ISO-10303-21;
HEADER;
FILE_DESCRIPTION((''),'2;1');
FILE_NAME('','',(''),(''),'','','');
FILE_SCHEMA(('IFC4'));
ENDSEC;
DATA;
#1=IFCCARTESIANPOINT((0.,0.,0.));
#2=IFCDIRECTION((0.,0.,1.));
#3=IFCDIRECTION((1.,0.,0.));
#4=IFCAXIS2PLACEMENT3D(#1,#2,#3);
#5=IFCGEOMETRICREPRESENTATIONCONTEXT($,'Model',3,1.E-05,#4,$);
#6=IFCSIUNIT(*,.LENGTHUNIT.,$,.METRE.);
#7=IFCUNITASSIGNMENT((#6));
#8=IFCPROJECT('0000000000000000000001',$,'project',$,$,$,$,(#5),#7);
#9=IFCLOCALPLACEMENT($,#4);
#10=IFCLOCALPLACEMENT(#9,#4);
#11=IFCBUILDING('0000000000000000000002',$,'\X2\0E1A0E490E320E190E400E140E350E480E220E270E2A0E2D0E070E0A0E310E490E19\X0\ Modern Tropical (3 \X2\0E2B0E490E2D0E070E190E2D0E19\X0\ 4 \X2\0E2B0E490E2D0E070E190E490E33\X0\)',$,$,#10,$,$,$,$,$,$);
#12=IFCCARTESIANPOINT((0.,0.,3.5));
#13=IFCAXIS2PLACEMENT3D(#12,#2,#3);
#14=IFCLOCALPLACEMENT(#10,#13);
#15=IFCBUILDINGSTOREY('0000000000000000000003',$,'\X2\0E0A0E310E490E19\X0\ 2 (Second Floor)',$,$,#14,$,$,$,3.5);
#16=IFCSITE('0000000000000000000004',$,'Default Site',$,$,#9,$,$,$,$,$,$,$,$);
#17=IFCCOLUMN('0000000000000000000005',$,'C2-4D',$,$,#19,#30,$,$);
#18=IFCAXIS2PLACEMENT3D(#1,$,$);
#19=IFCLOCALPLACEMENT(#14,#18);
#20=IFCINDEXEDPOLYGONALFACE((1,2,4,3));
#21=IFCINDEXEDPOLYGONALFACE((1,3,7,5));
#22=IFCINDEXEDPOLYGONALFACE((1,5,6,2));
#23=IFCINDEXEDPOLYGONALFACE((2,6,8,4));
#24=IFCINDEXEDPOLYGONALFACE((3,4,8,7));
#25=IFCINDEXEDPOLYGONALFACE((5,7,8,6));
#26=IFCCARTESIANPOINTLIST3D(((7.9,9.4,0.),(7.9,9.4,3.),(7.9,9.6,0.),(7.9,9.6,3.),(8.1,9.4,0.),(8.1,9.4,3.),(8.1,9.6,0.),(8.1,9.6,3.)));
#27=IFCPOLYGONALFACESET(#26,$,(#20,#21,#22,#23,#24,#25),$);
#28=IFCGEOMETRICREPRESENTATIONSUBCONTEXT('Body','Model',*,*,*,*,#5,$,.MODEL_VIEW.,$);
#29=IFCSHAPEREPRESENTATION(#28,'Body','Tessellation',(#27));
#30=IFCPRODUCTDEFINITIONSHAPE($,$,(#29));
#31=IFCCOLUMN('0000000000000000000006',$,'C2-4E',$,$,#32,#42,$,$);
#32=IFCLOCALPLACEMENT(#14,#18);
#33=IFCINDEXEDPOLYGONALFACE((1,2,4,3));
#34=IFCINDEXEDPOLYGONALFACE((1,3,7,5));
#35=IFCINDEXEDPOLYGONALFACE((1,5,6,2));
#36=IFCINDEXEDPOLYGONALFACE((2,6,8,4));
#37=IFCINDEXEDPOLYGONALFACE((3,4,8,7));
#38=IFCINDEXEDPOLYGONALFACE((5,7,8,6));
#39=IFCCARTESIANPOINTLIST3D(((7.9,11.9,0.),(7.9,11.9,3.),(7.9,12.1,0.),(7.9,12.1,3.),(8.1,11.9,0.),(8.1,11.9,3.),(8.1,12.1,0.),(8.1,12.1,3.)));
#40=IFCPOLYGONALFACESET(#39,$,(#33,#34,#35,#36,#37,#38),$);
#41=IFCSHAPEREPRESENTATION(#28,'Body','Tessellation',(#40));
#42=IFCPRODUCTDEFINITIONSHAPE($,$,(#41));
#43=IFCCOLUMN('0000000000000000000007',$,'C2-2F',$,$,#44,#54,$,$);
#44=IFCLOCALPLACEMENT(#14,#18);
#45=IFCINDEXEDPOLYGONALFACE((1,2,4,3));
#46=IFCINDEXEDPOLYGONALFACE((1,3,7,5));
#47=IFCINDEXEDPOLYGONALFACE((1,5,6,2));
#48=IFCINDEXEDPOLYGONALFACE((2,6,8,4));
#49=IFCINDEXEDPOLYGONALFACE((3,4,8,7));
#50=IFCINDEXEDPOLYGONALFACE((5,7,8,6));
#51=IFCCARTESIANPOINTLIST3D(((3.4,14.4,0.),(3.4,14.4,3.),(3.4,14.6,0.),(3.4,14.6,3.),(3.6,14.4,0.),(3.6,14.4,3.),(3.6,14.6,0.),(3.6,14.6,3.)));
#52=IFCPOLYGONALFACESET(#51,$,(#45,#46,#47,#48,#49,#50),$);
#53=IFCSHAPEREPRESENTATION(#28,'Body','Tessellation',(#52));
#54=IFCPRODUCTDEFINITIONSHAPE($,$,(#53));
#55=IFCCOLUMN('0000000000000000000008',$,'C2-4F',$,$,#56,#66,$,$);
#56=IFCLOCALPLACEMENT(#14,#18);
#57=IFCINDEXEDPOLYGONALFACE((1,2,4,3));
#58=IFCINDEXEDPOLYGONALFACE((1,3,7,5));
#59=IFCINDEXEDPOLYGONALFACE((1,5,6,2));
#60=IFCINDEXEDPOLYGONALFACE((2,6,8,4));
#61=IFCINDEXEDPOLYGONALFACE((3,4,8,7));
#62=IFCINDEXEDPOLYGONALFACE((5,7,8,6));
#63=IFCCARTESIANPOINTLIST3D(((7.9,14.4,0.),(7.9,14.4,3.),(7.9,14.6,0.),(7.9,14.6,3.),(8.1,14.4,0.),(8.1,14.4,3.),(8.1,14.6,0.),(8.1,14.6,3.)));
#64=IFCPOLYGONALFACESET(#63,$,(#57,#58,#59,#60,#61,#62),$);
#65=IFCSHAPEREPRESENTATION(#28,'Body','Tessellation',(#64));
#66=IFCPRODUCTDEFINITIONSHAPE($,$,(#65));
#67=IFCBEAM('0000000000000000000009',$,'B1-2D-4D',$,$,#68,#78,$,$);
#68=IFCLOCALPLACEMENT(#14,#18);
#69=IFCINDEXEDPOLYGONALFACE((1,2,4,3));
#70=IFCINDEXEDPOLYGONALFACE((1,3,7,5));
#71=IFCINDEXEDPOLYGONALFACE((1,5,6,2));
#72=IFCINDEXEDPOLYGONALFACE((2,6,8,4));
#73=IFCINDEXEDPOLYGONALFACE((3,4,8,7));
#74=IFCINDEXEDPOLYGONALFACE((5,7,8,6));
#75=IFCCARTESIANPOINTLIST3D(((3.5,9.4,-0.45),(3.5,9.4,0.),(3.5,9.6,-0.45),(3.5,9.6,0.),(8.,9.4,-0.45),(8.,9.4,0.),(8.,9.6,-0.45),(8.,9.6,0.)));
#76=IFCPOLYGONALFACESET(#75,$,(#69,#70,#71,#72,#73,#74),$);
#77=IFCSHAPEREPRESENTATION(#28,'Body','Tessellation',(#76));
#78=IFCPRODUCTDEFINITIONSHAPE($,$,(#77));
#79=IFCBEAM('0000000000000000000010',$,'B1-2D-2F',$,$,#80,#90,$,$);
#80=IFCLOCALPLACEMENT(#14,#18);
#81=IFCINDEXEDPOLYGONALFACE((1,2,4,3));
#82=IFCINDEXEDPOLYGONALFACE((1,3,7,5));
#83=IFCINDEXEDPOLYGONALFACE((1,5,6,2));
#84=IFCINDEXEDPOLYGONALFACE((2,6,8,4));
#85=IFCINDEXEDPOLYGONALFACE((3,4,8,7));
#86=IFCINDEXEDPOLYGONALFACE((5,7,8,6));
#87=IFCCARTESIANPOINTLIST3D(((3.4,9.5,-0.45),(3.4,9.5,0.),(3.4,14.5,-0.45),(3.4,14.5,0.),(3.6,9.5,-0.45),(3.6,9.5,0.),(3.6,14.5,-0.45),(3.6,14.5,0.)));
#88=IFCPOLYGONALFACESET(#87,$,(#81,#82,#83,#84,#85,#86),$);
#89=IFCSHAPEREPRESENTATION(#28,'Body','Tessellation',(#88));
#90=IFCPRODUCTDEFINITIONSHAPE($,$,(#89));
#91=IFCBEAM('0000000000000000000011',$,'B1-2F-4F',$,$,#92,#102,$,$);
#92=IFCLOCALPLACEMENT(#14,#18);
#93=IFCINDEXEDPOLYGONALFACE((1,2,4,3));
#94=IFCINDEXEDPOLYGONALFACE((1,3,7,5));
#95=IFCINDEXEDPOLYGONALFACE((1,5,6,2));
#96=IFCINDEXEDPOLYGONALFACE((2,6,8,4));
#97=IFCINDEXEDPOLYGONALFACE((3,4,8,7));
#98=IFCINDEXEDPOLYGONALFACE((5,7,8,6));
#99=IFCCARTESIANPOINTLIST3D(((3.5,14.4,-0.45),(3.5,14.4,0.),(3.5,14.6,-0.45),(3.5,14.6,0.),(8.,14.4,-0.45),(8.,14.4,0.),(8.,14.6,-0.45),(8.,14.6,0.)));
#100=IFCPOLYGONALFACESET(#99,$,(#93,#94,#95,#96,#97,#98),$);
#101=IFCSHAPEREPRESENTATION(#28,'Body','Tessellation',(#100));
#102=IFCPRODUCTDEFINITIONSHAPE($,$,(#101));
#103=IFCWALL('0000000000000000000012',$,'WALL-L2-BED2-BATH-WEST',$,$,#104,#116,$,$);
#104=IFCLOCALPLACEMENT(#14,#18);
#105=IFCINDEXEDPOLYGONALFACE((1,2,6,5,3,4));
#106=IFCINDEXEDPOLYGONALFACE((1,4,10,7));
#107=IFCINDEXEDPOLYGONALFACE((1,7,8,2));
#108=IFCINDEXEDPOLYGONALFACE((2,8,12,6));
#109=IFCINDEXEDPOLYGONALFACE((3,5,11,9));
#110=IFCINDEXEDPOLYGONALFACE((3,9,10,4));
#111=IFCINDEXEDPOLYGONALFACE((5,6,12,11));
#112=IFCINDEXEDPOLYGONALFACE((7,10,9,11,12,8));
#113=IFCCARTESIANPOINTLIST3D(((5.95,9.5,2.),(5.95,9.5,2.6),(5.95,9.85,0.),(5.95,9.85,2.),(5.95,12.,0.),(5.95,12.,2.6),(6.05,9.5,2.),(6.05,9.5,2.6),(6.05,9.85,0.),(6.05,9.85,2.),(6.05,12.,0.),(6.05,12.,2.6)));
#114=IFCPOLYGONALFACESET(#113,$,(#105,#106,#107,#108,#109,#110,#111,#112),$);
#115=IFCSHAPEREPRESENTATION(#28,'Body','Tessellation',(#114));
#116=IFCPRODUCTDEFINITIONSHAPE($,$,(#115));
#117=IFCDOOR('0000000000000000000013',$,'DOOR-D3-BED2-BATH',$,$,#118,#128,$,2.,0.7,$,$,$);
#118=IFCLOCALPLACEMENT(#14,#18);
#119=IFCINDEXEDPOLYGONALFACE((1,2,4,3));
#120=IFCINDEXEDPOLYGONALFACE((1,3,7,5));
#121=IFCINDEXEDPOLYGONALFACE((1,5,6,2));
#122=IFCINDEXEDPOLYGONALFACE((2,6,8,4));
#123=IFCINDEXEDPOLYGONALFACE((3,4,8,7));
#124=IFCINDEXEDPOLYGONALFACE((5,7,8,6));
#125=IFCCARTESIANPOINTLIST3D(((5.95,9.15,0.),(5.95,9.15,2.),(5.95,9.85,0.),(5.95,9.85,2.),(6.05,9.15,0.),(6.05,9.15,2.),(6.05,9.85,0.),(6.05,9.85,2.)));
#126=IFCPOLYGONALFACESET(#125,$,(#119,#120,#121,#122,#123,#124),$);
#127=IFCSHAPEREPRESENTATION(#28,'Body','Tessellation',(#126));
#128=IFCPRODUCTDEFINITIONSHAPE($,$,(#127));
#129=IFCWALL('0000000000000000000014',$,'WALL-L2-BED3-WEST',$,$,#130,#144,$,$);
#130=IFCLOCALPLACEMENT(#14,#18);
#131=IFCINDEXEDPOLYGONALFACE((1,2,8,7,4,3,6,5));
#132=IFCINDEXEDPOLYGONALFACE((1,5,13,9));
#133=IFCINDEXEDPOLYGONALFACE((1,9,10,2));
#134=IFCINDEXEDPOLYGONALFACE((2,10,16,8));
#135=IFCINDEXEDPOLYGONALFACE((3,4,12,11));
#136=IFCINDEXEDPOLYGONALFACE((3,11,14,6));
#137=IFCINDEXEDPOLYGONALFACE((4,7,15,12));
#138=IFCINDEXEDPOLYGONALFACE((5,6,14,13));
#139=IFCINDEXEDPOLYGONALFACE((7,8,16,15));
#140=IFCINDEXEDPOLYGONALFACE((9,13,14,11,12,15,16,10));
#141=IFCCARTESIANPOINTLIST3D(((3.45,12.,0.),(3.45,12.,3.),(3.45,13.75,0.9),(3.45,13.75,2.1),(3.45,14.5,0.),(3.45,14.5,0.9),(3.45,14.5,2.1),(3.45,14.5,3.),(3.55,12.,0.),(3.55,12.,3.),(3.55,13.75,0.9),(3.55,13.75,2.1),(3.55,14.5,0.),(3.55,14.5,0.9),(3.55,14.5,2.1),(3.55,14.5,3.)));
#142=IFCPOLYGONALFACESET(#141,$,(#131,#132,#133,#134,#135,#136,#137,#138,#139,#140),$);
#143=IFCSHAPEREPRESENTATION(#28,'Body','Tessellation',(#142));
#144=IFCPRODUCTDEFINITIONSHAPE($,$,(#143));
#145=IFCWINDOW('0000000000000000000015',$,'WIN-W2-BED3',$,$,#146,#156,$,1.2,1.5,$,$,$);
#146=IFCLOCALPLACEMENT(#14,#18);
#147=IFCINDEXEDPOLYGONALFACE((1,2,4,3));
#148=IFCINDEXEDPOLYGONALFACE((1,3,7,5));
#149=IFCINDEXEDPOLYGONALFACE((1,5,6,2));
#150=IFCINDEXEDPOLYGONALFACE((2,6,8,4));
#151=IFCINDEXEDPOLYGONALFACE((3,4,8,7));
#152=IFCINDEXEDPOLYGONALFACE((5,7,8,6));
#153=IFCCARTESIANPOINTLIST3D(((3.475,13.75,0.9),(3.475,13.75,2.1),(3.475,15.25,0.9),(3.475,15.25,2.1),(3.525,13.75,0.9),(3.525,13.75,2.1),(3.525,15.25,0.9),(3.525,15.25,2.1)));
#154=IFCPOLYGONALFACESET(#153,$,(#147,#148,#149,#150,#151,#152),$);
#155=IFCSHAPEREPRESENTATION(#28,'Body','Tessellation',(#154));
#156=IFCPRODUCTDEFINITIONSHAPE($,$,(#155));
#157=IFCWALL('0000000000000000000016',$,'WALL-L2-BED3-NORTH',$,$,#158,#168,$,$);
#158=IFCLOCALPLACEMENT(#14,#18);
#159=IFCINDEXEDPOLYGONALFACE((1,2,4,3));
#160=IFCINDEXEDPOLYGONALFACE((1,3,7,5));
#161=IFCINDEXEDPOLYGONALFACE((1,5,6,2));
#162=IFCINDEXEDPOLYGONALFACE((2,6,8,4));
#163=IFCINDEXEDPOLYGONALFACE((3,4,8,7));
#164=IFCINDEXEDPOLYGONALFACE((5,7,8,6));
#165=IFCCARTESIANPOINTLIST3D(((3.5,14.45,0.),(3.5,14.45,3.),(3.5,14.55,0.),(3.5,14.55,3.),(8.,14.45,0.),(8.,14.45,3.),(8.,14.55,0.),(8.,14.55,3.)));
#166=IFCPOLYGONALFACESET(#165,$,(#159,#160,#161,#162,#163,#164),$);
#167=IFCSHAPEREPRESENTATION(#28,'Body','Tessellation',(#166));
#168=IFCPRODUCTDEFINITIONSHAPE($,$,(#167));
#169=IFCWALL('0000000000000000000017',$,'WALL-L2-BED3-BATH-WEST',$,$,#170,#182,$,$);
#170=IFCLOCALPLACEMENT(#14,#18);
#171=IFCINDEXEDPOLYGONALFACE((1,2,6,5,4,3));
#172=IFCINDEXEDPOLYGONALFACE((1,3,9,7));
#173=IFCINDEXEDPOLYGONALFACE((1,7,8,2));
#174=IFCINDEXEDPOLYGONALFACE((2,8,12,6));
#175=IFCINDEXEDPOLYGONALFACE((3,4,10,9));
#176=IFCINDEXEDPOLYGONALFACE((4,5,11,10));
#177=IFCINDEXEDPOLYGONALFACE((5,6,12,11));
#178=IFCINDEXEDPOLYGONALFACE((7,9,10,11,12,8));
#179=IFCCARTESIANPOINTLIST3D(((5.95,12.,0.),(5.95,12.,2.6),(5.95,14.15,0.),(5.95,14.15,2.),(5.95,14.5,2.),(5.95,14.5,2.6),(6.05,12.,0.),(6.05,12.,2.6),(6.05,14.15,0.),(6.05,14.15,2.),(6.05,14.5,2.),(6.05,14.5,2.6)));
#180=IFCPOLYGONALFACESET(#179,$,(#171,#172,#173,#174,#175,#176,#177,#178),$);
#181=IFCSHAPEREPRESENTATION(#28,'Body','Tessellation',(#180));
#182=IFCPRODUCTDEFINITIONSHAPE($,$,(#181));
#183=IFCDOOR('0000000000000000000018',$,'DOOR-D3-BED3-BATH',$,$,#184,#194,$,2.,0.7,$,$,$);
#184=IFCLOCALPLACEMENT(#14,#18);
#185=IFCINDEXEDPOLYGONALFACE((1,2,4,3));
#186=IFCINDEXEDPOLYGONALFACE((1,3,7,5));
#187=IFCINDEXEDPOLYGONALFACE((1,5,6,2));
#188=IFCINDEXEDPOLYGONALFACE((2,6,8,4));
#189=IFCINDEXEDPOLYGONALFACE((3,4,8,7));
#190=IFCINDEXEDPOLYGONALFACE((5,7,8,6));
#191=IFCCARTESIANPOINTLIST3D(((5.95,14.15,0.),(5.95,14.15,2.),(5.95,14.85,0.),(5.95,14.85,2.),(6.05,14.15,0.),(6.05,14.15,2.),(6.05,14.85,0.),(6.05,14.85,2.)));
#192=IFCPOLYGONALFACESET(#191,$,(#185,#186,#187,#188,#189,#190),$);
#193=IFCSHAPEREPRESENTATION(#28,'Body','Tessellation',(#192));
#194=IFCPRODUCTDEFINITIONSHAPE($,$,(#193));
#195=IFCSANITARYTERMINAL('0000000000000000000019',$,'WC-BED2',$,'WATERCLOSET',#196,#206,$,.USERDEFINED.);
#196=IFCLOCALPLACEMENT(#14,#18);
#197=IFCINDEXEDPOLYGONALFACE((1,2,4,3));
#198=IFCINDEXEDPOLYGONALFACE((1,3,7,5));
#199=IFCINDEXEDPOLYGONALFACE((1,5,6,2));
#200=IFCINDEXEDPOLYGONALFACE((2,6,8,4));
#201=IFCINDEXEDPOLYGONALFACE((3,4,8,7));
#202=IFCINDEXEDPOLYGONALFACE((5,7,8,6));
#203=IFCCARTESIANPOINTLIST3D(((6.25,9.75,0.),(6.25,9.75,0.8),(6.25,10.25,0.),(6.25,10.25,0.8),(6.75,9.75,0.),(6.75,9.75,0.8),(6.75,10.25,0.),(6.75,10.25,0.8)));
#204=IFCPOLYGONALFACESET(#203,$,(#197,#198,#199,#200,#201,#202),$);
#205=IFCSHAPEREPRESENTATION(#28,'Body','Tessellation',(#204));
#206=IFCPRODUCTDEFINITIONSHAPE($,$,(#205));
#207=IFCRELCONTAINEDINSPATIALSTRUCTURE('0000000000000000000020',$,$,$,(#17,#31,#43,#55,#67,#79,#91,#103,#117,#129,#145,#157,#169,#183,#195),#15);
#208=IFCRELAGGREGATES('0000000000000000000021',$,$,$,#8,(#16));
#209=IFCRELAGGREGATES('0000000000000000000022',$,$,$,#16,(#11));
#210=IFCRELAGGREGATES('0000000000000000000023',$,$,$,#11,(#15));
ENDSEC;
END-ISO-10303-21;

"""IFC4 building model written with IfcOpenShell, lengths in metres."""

from ifc_helpers import new_model, si_unit, frame, origin_with_axes, origin_2d, place, context, subcontext, project, spatial, rectangle, extrude, element, fill, save


model = new_model("IFC4")

# Units and contexts
model_context = context("Model", 3, precision=1e-05, world=origin_with_axes())
body_context = subcontext(model_context, "Body", "Model", "MODEL_VIEW")
ifc_project = project(units=[si_unit("LENGTHUNIT", "METRE")], contexts=[model_context])

# Site, building, storey
site_placement = place(None, origin_with_axes())
site = spatial("IfcSite", under=ifc_project, at=site_placement, Name="Default Site")
building_placement = place(site_placement, origin_with_axes())
building = spatial("IfcBuilding", under=site, at=building_placement, Name="บ้านเดี่ยวสองชั้น Modern Tropical (3 ห้องนอน 4 ห้องน้ำ)")
storey_placement = place(building_placement, frame((0.0, 0.0, 3.5), z_axis=(0.0, 0.0, 1.0), x_axis=(1.0, 0.0, 0.0)))
storey = spatial("IfcBuildingStorey", under=building, at=storey_placement, Name="ชั้น 2 (Second Floor)", Elevation=3.5)

# Columns
for number, where, z_axis, x_axis, name in (
    (1, (8.0, 9.5, 0.0), (0.0, 0.0, 1.0), (1.0, 0.0, 0.0), "C2-4D"),
    (2, (8.0, 12.0, 0.0), (0.0, 0.0, 1.0), (1.0, 0.0, 0.0), "C2-4E"),
    (3, (3.5, 14.5, 0.0), (0.0, 0.0, 1.0), (1.0, 0.0, 0.0), "C2-2F"),
    (4, (8.0, 14.5, 0.0), (0.0, 0.0, 1.0), (1.0, 0.0, 0.0), "C2-4F"),
):
    element("IfcColumn", number, at=place(storey_placement, frame(where, z_axis=z_axis, x_axis=x_axis)), inside=storey, Name=name, context=body_context, shape_type="SweptSolid", body=[
        extrude(rectangle(XDim=0.2, YDim=0.2, at=origin_2d()), origin_with_axes(), (0.0, 0.0, 1.0), 3.0),
    ])

# Beams
beam_1_placement = place(storey_placement, frame((3.5, 9.5, -0.225), z_axis=(1.0, 0.0, 0.0), x_axis=(0.0, 1.0, 0.0)))
element("IfcBeam", 5, at=beam_1_placement, inside=storey, Name="B1-2D-4D", context=body_context, shape_type="SweptSolid", body=[
    extrude(rectangle(XDim=0.2, YDim=0.45, at=origin_2d()), origin_with_axes(), (0.0, 0.0, 1.0), 4.5),
])
beam_2_placement = place(storey_placement, frame((3.5, 9.5, -0.225), z_axis=(0.0, 1.0, 0.0), x_axis=(-1.0, 0.0, 0.0)))
element("IfcBeam", 6, at=beam_2_placement, inside=storey, Name="B1-2D-2F", context=body_context, shape_type="SweptSolid", body=[
    extrude(rectangle(XDim=0.2, YDim=0.45, at=origin_2d()), origin_with_axes(), (0.0, 0.0, 1.0), 5.0),
])
beam_3_placement = place(storey_placement, frame((3.5, 14.5, -0.225), z_axis=(1.0, 0.0, 0.0), x_axis=(0.0, 1.0, 0.0)))
element("IfcBeam", 7, at=beam_3_placement, inside=storey, Name="B1-2F-4F", context=body_context, shape_type="SweptSolid", body=[
    extrude(rectangle(XDim=0.2, YDim=0.45, at=origin_2d()), origin_with_axes(), (0.0, 0.0, 1.0), 4.5),
])

# Wall, opening, door
wall_1_placement = place(storey_placement, frame((6.0, 10.75, 0.0), z_axis=(0.0, 0.0, 1.0), x_axis=(0.0, 1.0, 0.0)))
wall_1 = element("IfcWall", 8, at=wall_1_placement, inside=storey, Name="WALL-L2-BED2-BATH-WEST", context=body_context, shape_type="SweptSolid", body=[
    extrude(rectangle(XDim=2.5, YDim=0.1, at=origin_2d()), origin_with_axes(), (0.0, 0.0, 1.0), 2.6),
])
opening_1_placement = place(wall_1_placement, frame((-1.25, 0.0, 0.0), z_axis=(0.0, 0.0, 1.0), x_axis=(1.0, 0.0, 0.0)))
opening_1 = element("IfcOpeningElement", 9, at=opening_1_placement, cuts=wall_1, context=body_context, shape_type="SweptSolid", body=[
    extrude(rectangle(XDim=0.7, YDim=0.12, at=origin_2d()), origin_with_axes(), (0.0, 0.0, 1.0), 2.0),
])
door_1_placement = place(opening_1_placement, origin_with_axes())
door_1 = element("IfcDoor", 10, at=door_1_placement, inside=storey, Name="DOOR-D3-BED2-BATH", OverallHeight=2.0, OverallWidth=0.7, context=body_context, shape_type="SweptSolid", body=[
    extrude(rectangle(XDim=0.7, YDim=0.1, at=origin_2d()), origin_with_axes(), (0.0, 0.0, 1.0), 2.0),
])
fill(opening_1, door_1)

# Wall, opening, window
wall_2_placement = place(storey_placement, frame((3.5, 13.25, 0.0), z_axis=(0.0, 0.0, 1.0), x_axis=(0.0, 1.0, 0.0)))
wall_2 = element("IfcWall", 11, at=wall_2_placement, inside=storey, Name="WALL-L2-BED3-WEST", context=body_context, shape_type="SweptSolid", body=[
    extrude(rectangle(XDim=2.5, YDim=0.1, at=origin_2d()), origin_with_axes(), (0.0, 0.0, 1.0), 3.0),
])
opening_2_placement = place(wall_2_placement, frame((1.25, 0.0, 0.9), z_axis=(0.0, 0.0, 1.0), x_axis=(1.0, 0.0, 0.0)))
opening_2 = element("IfcOpeningElement", 12, at=opening_2_placement, cuts=wall_2, context=body_context, shape_type="SweptSolid", body=[
    extrude(rectangle(XDim=1.5, YDim=0.12, at=origin_2d()), origin_with_axes(), (0.0, 0.0, 1.0), 1.2),
])
window_placement = place(opening_2_placement, origin_with_axes())
window = element("IfcWindow", 13, at=window_placement, inside=storey, Name="WIN-W2-BED3", OverallHeight=1.2, OverallWidth=1.5, context=body_context, shape_type="SweptSolid", body=[
    extrude(rectangle(XDim=1.5, YDim=0.05, at=origin_2d()), origin_with_axes(), (0.0, 0.0, 1.0), 1.2),
])
fill(opening_2, window)

# Wall
wall_3_placement = place(storey_placement, frame((5.75, 14.5, 0.0), z_axis=(0.0, 0.0, 1.0), x_axis=(1.0, 0.0, 0.0)))
element("IfcWall", 14, at=wall_3_placement, inside=storey, Name="WALL-L2-BED3-NORTH", context=body_context, shape_type="SweptSolid", body=[
    extrude(rectangle(XDim=4.5, YDim=0.1, at=origin_2d()), origin_with_axes(), (0.0, 0.0, 1.0), 3.0),
])

# Wall, opening, door
wall_4_placement = place(storey_placement, frame((6.0, 13.25, 0.0), z_axis=(0.0, 0.0, 1.0), x_axis=(0.0, 1.0, 0.0)))
wall_4 = element("IfcWall", 15, at=wall_4_placement, inside=storey, Name="WALL-L2-BED3-BATH-WEST", context=body_context, shape_type="SweptSolid", body=[
    extrude(rectangle(XDim=2.5, YDim=0.1, at=origin_2d()), origin_with_axes(), (0.0, 0.0, 1.0), 2.6),
])
opening_3_placement = place(wall_4_placement, frame((1.25, 0.0, 0.0), z_axis=(0.0, 0.0, 1.0), x_axis=(1.0, 0.0, 0.0)))
opening_3 = element("IfcOpeningElement", 16, at=opening_3_placement, cuts=wall_4, context=body_context, shape_type="SweptSolid", body=[
    extrude(rectangle(XDim=0.7, YDim=0.12, at=origin_2d()), origin_with_axes(), (0.0, 0.0, 1.0), 2.0),
])
door_2_placement = place(opening_3_placement, origin_with_axes())
door_2 = element("IfcDoor", 17, at=door_2_placement, inside=storey, Name="DOOR-D3-BED3-BATH", OverallHeight=2.0, OverallWidth=0.7, context=body_context, shape_type="SweptSolid", body=[
    extrude(rectangle(XDim=0.7, YDim=0.1, at=origin_2d()), origin_with_axes(), (0.0, 0.0, 1.0), 2.0),
])
fill(opening_3, door_2)

# Sanitary terminal
sanitary_terminal_1_placement = place(storey_placement, frame((6.5, 10.0, 0.0), z_axis=(0.0, 0.0, 1.0), x_axis=(1.0, 0.0, 0.0)))
element("IfcSanitaryTerminal", 18, at=sanitary_terminal_1_placement, inside=storey, Name="WC-BED2", ObjectType="WATERCLOSET", PredefinedType="USERDEFINED", context=body_context, shape_type="SweptSolid", body=[
    extrude(rectangle(XDim=0.5, YDim=0.5, at=origin_2d()), origin_with_axes(), (0.0, 0.0, 1.0), 0.8),
])

save(model, "model.ifc")
